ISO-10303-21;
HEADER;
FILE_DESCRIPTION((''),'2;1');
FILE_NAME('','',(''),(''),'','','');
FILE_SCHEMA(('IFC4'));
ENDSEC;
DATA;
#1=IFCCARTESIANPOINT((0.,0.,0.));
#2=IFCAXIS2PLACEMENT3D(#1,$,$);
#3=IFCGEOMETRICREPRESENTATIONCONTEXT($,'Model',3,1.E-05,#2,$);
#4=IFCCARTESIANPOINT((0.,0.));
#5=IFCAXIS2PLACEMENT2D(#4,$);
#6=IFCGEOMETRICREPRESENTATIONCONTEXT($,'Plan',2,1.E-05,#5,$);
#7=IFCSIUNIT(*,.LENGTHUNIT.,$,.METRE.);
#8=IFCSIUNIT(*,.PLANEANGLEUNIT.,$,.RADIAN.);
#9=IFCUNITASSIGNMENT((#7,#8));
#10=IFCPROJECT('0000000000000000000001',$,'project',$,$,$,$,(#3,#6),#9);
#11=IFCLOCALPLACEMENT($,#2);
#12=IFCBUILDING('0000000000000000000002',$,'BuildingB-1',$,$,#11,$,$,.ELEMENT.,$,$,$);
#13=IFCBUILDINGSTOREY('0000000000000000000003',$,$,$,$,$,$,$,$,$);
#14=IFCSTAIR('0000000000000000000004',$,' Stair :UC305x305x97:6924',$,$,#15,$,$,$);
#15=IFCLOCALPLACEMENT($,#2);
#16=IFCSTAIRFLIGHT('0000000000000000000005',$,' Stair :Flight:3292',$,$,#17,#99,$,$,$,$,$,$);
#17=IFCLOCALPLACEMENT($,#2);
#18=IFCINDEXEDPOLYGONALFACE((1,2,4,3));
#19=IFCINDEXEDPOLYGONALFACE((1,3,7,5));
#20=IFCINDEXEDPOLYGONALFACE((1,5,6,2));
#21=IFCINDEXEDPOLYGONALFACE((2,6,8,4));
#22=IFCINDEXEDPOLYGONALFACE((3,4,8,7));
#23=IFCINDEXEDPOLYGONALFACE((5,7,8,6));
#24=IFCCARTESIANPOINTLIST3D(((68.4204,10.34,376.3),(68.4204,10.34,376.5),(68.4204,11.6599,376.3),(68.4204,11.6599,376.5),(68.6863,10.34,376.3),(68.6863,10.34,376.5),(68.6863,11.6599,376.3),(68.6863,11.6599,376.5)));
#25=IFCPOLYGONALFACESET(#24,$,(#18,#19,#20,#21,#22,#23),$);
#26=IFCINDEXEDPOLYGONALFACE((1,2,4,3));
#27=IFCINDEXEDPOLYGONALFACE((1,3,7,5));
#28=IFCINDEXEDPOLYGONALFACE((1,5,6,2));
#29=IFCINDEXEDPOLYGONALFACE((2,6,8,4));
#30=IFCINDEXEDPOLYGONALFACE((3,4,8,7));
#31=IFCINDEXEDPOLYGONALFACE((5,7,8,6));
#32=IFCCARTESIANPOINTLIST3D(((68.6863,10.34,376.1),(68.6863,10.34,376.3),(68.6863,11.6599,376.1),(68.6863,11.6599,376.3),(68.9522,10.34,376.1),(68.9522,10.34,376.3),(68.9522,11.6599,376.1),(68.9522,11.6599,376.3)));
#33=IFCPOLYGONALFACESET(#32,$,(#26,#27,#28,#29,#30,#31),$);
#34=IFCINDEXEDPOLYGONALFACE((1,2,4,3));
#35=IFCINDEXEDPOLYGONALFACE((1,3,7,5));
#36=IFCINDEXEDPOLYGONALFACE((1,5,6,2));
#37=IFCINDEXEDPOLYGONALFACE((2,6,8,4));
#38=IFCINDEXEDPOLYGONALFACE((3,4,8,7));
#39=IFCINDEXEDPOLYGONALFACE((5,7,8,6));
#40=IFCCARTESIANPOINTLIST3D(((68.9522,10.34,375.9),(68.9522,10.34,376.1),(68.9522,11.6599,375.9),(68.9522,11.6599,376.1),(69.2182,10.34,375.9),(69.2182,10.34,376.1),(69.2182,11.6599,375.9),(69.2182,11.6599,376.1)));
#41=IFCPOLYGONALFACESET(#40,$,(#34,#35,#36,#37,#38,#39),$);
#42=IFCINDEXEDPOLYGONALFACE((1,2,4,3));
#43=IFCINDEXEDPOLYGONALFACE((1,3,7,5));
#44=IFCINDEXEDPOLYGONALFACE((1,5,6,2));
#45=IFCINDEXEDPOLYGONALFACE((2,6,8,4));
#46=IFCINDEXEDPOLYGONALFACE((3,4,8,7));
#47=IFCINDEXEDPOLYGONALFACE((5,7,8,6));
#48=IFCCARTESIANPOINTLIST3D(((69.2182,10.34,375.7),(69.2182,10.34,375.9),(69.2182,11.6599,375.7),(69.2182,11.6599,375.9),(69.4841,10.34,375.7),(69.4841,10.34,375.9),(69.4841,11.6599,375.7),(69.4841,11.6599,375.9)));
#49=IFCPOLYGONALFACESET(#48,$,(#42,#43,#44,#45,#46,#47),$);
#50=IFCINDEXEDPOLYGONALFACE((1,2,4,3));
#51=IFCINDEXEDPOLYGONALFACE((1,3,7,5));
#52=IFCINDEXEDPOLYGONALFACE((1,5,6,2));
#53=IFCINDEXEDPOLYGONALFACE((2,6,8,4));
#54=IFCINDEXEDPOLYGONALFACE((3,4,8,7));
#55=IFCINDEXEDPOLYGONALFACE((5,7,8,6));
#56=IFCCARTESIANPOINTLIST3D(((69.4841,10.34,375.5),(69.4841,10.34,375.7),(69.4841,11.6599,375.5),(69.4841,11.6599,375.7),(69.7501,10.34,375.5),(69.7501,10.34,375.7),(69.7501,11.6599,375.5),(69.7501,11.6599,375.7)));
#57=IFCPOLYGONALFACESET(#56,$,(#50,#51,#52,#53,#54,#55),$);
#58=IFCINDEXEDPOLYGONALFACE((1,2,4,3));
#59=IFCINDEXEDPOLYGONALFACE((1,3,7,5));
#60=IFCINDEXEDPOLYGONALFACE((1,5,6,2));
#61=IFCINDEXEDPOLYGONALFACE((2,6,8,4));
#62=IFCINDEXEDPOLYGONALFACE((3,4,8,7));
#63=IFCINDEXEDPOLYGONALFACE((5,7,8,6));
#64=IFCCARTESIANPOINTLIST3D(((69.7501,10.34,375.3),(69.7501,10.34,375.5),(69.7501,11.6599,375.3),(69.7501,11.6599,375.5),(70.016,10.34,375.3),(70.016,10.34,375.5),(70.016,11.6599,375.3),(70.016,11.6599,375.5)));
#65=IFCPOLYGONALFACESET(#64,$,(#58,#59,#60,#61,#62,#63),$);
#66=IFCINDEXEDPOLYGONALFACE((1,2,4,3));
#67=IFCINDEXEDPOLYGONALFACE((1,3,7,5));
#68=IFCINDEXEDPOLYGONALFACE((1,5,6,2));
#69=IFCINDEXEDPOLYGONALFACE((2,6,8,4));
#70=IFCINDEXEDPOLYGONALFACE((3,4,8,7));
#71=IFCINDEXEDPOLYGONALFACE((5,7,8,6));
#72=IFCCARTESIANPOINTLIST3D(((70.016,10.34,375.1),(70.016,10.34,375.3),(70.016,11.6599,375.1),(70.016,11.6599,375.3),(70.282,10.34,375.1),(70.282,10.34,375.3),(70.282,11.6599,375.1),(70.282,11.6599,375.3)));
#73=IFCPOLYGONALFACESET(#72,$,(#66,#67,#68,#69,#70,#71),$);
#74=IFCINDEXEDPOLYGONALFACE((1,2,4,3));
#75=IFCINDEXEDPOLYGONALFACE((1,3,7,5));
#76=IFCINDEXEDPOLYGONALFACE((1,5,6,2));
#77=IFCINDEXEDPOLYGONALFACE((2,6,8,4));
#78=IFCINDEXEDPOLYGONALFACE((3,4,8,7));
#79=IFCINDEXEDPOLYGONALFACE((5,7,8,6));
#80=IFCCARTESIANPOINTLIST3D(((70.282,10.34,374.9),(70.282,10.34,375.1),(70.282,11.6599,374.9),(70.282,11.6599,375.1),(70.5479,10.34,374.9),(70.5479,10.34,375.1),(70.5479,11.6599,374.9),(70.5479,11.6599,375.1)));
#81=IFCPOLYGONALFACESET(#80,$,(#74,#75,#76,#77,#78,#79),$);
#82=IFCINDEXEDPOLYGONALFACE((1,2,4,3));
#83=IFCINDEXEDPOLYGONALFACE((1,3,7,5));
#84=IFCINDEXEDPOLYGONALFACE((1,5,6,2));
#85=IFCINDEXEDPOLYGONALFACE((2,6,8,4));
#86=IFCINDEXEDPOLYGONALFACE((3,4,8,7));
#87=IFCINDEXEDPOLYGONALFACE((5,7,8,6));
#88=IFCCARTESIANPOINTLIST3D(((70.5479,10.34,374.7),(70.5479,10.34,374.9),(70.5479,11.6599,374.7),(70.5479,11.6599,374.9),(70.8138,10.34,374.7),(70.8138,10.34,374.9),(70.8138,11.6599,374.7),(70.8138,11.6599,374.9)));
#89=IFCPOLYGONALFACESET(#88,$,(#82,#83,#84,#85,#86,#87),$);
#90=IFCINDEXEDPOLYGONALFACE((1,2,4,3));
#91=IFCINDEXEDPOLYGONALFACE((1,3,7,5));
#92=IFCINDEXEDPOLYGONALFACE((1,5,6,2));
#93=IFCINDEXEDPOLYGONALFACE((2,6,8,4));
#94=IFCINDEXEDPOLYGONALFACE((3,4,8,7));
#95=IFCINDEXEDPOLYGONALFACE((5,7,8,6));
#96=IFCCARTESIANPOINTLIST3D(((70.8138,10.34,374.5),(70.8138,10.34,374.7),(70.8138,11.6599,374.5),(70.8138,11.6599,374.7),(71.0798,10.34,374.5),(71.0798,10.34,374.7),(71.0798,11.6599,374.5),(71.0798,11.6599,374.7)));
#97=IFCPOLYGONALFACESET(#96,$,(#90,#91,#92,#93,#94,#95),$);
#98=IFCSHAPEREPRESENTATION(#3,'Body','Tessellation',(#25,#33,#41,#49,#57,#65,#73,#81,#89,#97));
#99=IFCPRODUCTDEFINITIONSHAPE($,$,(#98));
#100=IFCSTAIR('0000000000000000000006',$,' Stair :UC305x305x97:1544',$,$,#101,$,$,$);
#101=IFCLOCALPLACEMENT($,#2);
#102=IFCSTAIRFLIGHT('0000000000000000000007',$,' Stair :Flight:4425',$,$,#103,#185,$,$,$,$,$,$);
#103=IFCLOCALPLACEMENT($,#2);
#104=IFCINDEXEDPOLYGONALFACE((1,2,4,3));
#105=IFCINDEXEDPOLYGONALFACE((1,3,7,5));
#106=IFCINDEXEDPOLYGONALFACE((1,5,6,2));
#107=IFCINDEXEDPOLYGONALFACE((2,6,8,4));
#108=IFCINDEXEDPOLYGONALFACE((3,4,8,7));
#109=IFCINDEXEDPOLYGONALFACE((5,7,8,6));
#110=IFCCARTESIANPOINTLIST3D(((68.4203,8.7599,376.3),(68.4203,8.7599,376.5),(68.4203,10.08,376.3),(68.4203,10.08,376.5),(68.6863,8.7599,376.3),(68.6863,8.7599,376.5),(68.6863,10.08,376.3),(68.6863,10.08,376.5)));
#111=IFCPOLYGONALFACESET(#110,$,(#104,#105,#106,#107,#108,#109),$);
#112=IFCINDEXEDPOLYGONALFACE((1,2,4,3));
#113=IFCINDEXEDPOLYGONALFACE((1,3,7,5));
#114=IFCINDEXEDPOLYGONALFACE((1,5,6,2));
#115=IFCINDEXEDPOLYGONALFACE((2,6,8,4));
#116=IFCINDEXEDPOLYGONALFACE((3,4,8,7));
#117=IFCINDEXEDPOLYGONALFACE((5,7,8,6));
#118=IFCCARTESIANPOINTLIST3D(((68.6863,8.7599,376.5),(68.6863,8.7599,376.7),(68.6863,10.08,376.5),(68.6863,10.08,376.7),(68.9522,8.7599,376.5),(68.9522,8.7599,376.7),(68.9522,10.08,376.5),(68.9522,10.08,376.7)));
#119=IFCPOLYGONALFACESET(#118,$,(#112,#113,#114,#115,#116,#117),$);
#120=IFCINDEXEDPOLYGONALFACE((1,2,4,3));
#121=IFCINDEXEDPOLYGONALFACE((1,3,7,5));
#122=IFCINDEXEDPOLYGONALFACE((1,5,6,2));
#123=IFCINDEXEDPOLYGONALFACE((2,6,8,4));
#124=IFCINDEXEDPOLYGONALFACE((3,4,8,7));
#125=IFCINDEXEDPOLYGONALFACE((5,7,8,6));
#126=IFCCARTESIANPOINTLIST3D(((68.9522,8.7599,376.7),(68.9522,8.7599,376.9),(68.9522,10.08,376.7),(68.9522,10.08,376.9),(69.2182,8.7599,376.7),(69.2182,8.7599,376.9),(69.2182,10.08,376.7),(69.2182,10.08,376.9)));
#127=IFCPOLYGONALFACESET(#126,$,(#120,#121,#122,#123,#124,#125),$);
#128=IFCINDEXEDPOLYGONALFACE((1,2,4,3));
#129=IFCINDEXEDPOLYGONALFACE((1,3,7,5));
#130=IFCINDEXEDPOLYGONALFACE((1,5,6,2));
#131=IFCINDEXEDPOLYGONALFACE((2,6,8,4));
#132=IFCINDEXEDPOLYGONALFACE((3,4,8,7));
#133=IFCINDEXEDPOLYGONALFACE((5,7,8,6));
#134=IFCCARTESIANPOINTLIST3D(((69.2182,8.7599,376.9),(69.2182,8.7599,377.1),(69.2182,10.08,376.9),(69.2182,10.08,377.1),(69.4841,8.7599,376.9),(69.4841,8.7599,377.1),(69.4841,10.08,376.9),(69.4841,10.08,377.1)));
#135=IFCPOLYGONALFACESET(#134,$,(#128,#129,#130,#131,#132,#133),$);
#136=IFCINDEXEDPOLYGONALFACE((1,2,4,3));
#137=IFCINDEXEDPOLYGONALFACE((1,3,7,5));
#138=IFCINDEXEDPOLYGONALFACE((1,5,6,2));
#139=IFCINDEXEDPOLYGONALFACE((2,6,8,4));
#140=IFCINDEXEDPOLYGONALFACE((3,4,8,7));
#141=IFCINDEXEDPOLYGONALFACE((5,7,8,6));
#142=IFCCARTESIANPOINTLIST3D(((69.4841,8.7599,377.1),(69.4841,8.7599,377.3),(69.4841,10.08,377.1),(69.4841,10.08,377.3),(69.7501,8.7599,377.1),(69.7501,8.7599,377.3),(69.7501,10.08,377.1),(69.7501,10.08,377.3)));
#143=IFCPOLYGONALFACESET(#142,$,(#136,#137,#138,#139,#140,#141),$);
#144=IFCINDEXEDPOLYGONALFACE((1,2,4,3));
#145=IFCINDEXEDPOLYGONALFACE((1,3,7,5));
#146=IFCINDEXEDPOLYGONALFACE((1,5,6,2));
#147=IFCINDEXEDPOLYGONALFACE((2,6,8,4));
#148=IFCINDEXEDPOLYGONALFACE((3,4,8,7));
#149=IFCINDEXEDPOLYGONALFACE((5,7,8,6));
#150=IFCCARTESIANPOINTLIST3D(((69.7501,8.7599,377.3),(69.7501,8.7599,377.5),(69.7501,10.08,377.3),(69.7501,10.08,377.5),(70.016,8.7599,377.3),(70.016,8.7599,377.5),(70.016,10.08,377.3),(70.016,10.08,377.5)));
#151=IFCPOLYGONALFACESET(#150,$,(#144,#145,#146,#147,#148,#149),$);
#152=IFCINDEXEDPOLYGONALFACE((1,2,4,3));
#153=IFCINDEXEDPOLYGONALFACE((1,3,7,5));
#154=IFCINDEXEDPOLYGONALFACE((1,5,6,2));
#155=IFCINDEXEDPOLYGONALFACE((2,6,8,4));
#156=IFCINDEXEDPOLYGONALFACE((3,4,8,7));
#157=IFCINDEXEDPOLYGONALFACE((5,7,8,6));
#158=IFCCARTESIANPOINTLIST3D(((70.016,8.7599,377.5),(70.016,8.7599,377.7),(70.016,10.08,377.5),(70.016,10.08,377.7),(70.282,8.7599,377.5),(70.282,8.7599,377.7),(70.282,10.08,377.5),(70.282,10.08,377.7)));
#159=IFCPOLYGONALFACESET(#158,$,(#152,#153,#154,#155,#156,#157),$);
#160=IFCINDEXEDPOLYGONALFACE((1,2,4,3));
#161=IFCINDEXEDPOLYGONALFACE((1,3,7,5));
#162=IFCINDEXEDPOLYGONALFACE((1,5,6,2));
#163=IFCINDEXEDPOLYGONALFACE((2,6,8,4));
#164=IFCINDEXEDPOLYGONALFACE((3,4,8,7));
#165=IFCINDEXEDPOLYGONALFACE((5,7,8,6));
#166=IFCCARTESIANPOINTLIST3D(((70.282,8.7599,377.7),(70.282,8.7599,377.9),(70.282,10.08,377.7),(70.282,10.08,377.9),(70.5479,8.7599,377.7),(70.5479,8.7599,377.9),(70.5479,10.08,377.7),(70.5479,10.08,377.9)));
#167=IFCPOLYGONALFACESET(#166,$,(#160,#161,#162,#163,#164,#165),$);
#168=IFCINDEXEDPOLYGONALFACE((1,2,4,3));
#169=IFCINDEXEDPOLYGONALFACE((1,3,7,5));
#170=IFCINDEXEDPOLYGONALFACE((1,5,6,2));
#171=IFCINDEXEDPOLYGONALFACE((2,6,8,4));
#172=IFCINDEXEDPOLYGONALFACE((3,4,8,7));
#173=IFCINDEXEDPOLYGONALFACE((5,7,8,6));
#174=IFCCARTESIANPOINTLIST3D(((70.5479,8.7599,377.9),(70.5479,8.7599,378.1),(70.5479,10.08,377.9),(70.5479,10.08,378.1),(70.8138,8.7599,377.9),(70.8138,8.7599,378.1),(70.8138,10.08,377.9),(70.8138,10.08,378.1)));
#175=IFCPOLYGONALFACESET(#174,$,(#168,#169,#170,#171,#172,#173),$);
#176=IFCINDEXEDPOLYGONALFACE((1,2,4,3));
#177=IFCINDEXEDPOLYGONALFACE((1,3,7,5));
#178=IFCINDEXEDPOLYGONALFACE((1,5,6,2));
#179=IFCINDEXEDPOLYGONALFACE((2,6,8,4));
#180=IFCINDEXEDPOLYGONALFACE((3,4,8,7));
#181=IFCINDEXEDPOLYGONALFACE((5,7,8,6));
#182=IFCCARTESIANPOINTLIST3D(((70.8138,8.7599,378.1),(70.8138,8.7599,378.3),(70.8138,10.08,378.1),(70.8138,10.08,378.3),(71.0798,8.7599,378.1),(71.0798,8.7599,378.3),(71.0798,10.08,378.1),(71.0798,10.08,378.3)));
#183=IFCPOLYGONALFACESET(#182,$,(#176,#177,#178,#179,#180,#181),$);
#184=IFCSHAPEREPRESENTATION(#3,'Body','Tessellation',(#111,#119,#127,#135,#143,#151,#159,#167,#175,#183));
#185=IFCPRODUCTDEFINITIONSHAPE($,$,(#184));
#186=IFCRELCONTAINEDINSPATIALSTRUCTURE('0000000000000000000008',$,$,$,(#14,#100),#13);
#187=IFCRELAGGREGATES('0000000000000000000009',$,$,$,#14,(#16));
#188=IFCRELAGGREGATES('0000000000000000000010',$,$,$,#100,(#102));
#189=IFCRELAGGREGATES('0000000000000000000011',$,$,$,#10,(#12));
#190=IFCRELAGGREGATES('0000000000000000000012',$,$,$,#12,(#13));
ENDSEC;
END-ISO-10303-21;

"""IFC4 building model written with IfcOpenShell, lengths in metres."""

from ifc_helpers import new_model, si_unit, frame, origin, origin_2d, place, context, project, spatial, polyline, outline, extrude, element, aggregate, save


model = new_model("IFC4")

# Units and contexts
model_context = context("Model", 3, precision=1e-05, world=origin())
plan_context = context("Plan", 2, precision=1e-05, world=origin_2d())
ifc_project = project(units=[si_unit("LENGTHUNIT", "METRE"), si_unit("PLANEANGLEUNIT", "RADIAN")], contexts=[model_context, plan_context])

# Building, storey
building_placement = place(None, origin())
building = spatial("IfcBuilding", under=ifc_project, at=building_placement, Name="BuildingB-1", CompositionType="ELEMENT")
storey = spatial("IfcBuildingStorey", under=building)

# Stairs, stair flights
stair_1 = element("IfcStair", 1, inside=storey, Name=" Stair :UC305x305x97:6924")
stair_flight_1 = element("IfcStairFlight", 2, Name=" Stair :Flight:3292", context=model_context, shape_type="SweptSolid", body=[
    extrude(outline(polyline([(68.6863, 11.6599, 376.5), (68.6863, 10.34, 376.5), (68.4204, 10.34, 376.5), (68.4204, 11.6599, 376.5), (68.6863, 11.6599, 376.5)])), origin(), (0.0, 0.0, -1.0), 0.2),
    extrude(outline(polyline([(68.9522, 11.6599, 376.5), (68.9522, 10.34, 376.5), (68.6863, 10.34, 376.5), (68.6863, 11.6599, 376.5), (68.9522, 11.6599, 376.5)])), frame((0.0, 0.0, -0.2)), (0.0, 0.0, -1.0), 0.2),
    extrude(outline(polyline([(69.2182, 11.6599, 376.5), (69.2182, 10.34, 376.5), (68.9522, 10.34, 376.5), (68.9522, 11.6599, 376.5), (69.2182, 11.6599, 376.5)])), frame((0.0, 0.0, -0.4)), (0.0, 0.0, -1.0), 0.2),
    extrude(outline(polyline([(69.4841, 11.6599, 376.5), (69.4841, 10.34, 376.5), (69.2182, 10.34, 376.5), (69.2182, 11.6599, 376.5), (69.4841, 11.6599, 376.5)])), frame((0.0, 0.0, -0.6)), (0.0, 0.0, -1.0), 0.2),
    extrude(outline(polyline([(69.7501, 11.6599, 376.5), (69.7501, 10.34, 376.5), (69.4841, 10.34, 376.5), (69.4841, 11.6599, 376.5), (69.7501, 11.6599, 376.5)])), frame((0.0, 0.0, -0.8)), (0.0, 0.0, -1.0), 0.2),
    extrude(outline(polyline([(70.016, 11.6599, 376.5), (70.016, 10.34, 376.5), (69.7501, 10.34, 376.5), (69.7501, 11.6599, 376.5), (70.016, 11.6599, 376.5)])), frame((0.0, 0.0, -1.0)), (0.0, 0.0, -1.0), 0.2),
    extrude(outline(polyline([(70.282, 11.6599, 376.5), (70.282, 10.34, 376.5), (70.016, 10.34, 376.5), (70.016, 11.6599, 376.5), (70.282, 11.6599, 376.5)])), frame((0.0, 0.0, -1.2)), (0.0, 0.0, -1.0), 0.2),
    extrude(outline(polyline([(70.5479, 11.6599, 376.5), (70.5479, 10.34, 376.5), (70.282, 10.34, 376.5), (70.282, 11.6599, 376.5), (70.5479, 11.6599, 376.5)])), frame((0.0, 0.0, -1.4)), (0.0, 0.0, -1.0), 0.2),
    extrude(outline(polyline([(70.8138, 11.6599, 376.5), (70.8138, 10.34, 376.5), (70.5479, 10.34, 376.5), (70.5479, 11.6599, 376.5), (70.8138, 11.6599, 376.5)])), frame((0.0, 0.0, -1.6)), (0.0, 0.0, -1.0), 0.2),
    extrude(outline(polyline([(71.0798, 11.6599, 376.5), (71.0798, 10.34, 376.5), (70.8138, 10.34, 376.5), (70.8138, 11.6599, 376.5), (71.0798, 11.6599, 376.5)])), frame((0.0, 0.0, -1.8)), (0.0, 0.0, -1.0), 0.2),
])
aggregate(stair_1, [stair_flight_1])
stair_2 = element("IfcStair", 3, inside=storey, Name=" Stair :UC305x305x97:1544")
stair_flight_2 = element("IfcStairFlight", 4, Name=" Stair :Flight:4425", context=model_context, shape_type="SweptSolid", body=[
    extrude(outline(polyline([(68.6863, 8.7599, 376.5), (68.6863, 10.08, 376.5), (68.4203, 10.08, 376.5), (68.4203, 8.7599, 376.5), (68.6863, 8.7599, 376.5)])), origin(), (0.0, 0.0, -1.0), 0.2),
    extrude(outline(polyline([(68.9522, 8.7599, 376.5), (68.9522, 10.08, 376.5), (68.6863, 10.08, 376.5), (68.6863, 8.7599, 376.5), (68.9522, 8.7599, 376.5)])), frame((0.0, 0.0, 0.2)), (0.0, 0.0, -1.0), 0.2),
    extrude(outline(polyline([(69.2182, 8.7599, 376.5), (69.2182, 10.08, 376.5), (68.9522, 10.08, 376.5), (68.9522, 8.7599, 376.5), (69.2182, 8.7599, 376.5)])), frame((0.0, 0.0, 0.4)), (0.0, 0.0, -1.0), 0.2),
    extrude(outline(polyline([(69.4841, 8.7599, 376.5), (69.4841, 10.08, 376.5), (69.2182, 10.08, 376.5), (69.2182, 8.7599, 376.5), (69.4841, 8.7599, 376.5)])), frame((0.0, 0.0, 0.6)), (0.0, 0.0, -1.0), 0.2),
    extrude(outline(polyline([(69.7501, 8.7599, 376.5), (69.7501, 10.08, 376.5), (69.4841, 10.08, 376.5), (69.4841, 8.7599, 376.5), (69.7501, 8.7599, 376.5)])), frame((0.0, 0.0, 0.8)), (0.0, 0.0, -1.0), 0.2),
    extrude(outline(polyline([(70.016, 8.7599, 376.5), (70.016, 10.08, 376.5), (69.7501, 10.08, 376.5), (69.7501, 8.7599, 376.5), (70.016, 8.7599, 376.5)])), frame((0.0, 0.0, 1.0)), (0.0, 0.0, -1.0), 0.2),
    extrude(outline(polyline([(70.282, 8.7599, 376.5), (70.282, 10.08, 376.5), (70.016, 10.08, 376.5), (70.016, 8.7599, 376.5), (70.282, 8.7599, 376.5)])), frame((0.0, 0.0, 1.2)), (0.0, 0.0, -1.0), 0.2),
    extrude(outline(polyline([(70.5479, 8.7599, 376.5), (70.5479, 10.08, 376.5), (70.282, 10.08, 376.5), (70.282, 8.7599, 376.5), (70.5479, 8.7599, 376.5)])), frame((0.0, 0.0, 1.4)), (0.0, 0.0, -1.0), 0.2),
    extrude(outline(polyline([(70.8138, 8.7599, 376.5), (70.8138, 10.08, 376.5), (70.5479, 10.08, 376.5), (70.5479, 8.7599, 376.5), (70.8138, 8.7599, 376.5)])), frame((0.0, 0.0, 1.6)), (0.0, 0.0, -1.0), 0.2),
    extrude(outline(polyline([(71.0798, 8.7599, 376.5), (71.0798, 10.08, 376.5), (70.8138, 10.08, 376.5), (70.8138, 8.7599, 376.5), (71.0798, 8.7599, 376.5)])), frame((0.0, 0.0, 1.8)), (0.0, 0.0, -1.0), 0.2),
])
aggregate(stair_2, [stair_flight_2])

save(model, "model.ifc")
